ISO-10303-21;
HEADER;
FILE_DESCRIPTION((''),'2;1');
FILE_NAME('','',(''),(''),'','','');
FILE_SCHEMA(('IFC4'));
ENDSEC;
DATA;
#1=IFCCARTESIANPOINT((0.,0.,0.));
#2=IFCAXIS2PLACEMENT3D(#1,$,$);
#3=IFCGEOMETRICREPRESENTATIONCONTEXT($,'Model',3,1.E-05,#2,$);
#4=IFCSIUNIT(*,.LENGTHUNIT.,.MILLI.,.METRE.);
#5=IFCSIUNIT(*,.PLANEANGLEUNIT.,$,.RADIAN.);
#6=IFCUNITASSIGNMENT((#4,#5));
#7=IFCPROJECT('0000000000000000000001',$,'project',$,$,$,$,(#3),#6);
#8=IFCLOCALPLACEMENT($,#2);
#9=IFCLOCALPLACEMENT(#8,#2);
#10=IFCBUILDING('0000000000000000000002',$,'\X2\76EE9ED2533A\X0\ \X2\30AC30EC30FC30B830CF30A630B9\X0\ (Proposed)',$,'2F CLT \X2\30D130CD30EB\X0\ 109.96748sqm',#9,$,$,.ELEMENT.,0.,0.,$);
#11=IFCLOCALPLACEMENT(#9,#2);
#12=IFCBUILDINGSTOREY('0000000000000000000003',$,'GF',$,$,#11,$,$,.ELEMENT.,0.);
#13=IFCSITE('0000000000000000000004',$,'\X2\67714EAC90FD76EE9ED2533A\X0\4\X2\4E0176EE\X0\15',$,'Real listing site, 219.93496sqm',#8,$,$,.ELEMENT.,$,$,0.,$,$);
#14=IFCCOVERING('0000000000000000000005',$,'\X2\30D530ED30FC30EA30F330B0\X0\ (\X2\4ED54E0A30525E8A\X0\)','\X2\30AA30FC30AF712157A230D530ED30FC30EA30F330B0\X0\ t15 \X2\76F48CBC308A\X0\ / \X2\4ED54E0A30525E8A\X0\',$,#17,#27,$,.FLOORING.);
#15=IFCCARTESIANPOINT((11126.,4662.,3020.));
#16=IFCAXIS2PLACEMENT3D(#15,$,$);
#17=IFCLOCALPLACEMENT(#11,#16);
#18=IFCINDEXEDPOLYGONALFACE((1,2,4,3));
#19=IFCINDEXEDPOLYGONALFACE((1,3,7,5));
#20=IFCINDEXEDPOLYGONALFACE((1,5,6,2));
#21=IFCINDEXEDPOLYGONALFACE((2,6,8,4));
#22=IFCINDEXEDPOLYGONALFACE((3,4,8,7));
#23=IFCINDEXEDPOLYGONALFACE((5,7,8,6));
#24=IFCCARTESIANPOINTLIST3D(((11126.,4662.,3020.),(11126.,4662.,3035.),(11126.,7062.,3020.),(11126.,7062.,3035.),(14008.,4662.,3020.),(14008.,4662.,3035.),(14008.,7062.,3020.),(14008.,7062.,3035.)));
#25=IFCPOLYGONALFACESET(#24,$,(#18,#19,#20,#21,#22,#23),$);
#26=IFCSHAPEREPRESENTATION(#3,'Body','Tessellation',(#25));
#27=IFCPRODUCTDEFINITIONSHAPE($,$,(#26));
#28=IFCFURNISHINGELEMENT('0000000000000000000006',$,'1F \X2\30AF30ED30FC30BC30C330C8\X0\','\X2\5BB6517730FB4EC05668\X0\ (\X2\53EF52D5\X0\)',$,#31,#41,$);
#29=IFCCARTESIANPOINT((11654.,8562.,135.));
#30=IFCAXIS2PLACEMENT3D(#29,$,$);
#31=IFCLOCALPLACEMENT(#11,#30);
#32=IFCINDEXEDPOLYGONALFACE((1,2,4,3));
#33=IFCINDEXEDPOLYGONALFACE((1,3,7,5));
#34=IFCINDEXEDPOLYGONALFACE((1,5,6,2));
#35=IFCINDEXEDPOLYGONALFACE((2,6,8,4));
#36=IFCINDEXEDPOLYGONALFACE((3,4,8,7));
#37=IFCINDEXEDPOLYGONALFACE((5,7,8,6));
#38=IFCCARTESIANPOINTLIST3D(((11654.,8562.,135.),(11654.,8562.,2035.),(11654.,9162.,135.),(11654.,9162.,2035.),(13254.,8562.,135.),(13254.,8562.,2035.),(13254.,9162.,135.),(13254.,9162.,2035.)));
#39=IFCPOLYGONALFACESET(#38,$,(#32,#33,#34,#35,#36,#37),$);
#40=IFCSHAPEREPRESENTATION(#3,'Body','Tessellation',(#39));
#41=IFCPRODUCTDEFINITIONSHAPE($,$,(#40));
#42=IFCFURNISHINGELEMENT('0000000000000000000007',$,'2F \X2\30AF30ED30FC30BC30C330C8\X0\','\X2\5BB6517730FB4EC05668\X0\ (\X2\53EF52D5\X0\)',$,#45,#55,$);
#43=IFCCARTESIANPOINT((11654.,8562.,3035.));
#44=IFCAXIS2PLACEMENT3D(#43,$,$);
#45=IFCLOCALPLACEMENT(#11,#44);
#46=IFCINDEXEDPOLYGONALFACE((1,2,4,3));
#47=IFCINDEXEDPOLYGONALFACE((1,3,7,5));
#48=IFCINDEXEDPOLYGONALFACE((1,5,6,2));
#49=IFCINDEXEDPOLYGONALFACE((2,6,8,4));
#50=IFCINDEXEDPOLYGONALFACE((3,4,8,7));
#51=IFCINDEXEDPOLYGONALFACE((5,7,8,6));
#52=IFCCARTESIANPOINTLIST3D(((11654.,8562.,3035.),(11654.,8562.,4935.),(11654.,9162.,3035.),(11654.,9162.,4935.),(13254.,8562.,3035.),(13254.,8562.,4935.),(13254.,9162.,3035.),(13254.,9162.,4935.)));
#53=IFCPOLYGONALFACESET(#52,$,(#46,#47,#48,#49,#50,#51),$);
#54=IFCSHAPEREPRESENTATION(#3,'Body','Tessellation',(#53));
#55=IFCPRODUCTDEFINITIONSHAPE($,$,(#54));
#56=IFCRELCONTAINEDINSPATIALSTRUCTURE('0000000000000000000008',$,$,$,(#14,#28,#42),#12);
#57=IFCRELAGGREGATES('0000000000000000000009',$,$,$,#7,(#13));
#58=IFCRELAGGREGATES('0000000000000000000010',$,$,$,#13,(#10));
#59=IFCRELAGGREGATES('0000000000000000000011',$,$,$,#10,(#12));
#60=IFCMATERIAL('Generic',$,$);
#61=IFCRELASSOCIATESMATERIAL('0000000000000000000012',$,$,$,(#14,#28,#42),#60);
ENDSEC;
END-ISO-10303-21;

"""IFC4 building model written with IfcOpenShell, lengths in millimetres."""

from ifc_helpers import new_model, si_unit, frame, frame_2d, origin, place, context, project, spatial, rectangle, extrude, material, element, save


model = new_model("IFC4")

# Units and contexts
model_context = context("Model", 3, precision=1e-05, world=origin())
ifc_project = project(units=[si_unit("LENGTHUNIT", "METRE", prefix="MILLI"), si_unit("PLANEANGLEUNIT", "RADIAN")], contexts=[model_context])

# Site, building, storey
site_placement = place(None, origin())
site = spatial("IfcSite", under=ifc_project, at=site_placement, Name="東京都目黒区4丁目15", ObjectType="Real listing site, 219.93496sqm", CompositionType="ELEMENT", RefElevation=0.0)
building_placement = place(site_placement, origin())
building = spatial("IfcBuilding", under=site, at=building_placement, Name="目黒区 ガレージハウス (Proposed)", ObjectType="2F CLT パネル 109.96748sqm", CompositionType="ELEMENT", ElevationOfRefHeight=0.0, ElevationOfTerrain=0.0)
storey_placement = place(building_placement, origin())
storey = spatial("IfcBuildingStorey", under=building, at=storey_placement, Name="GF", CompositionType="ELEMENT", Elevation=0.0)

# Covering
ifc_material_1 = material(Name="Generic")
covering_1_placement = place(storey_placement, frame((11126.0, 4662.0, 3020.0)))
element("IfcCovering", 1, at=covering_1_placement, inside=storey, material=ifc_material_1, Name="フローリング (仕上げ床)", Description="オーク無垢フローリング t15 直貼り / 仕上げ床", PredefinedType="FLOORING", context=model_context, shape_type="SweptSolid", body=[
    extrude(rectangle(XDim=2882.0, YDim=2400.0, at=frame_2d((1441.0, 1200.0))), frame((11126.0, 4662.0, 3020.0)), (0.0, 0.0, 1.0), 15.0),
])

# Furnishing elements
furnishing_1_placement = place(storey_placement, frame((11654.0, 8562.0, 135.0)))
element("IfcFurnishingElement", 2, at=furnishing_1_placement, inside=storey, material=ifc_material_1, Name="1F クローゼット", Description="家具・什器 (可動)", context=model_context, shape_type="SweptSolid", body=[
    extrude(rectangle(XDim=1600.0, YDim=600.0, at=frame_2d((800.0, 300.0))), frame((11654.0, 8562.0, 135.0)), (0.0, 0.0, 1.0), 1900.0),
])
furnishing_2_placement = place(storey_placement, frame((11654.0, 8562.0, 3035.0)))
element("IfcFurnishingElement", 3, at=furnishing_2_placement, inside=storey, material=ifc_material_1, Name="2F クローゼット", Description="家具・什器 (可動)", context=model_context, shape_type="SweptSolid", body=[
    extrude(rectangle(XDim=1600.0, YDim=600.0, at=frame_2d((800.0, 300.0))), frame((11654.0, 8562.0, 3035.0)), (0.0, 0.0, 1.0), 1900.0),
])

save(model, "model.ifc")
